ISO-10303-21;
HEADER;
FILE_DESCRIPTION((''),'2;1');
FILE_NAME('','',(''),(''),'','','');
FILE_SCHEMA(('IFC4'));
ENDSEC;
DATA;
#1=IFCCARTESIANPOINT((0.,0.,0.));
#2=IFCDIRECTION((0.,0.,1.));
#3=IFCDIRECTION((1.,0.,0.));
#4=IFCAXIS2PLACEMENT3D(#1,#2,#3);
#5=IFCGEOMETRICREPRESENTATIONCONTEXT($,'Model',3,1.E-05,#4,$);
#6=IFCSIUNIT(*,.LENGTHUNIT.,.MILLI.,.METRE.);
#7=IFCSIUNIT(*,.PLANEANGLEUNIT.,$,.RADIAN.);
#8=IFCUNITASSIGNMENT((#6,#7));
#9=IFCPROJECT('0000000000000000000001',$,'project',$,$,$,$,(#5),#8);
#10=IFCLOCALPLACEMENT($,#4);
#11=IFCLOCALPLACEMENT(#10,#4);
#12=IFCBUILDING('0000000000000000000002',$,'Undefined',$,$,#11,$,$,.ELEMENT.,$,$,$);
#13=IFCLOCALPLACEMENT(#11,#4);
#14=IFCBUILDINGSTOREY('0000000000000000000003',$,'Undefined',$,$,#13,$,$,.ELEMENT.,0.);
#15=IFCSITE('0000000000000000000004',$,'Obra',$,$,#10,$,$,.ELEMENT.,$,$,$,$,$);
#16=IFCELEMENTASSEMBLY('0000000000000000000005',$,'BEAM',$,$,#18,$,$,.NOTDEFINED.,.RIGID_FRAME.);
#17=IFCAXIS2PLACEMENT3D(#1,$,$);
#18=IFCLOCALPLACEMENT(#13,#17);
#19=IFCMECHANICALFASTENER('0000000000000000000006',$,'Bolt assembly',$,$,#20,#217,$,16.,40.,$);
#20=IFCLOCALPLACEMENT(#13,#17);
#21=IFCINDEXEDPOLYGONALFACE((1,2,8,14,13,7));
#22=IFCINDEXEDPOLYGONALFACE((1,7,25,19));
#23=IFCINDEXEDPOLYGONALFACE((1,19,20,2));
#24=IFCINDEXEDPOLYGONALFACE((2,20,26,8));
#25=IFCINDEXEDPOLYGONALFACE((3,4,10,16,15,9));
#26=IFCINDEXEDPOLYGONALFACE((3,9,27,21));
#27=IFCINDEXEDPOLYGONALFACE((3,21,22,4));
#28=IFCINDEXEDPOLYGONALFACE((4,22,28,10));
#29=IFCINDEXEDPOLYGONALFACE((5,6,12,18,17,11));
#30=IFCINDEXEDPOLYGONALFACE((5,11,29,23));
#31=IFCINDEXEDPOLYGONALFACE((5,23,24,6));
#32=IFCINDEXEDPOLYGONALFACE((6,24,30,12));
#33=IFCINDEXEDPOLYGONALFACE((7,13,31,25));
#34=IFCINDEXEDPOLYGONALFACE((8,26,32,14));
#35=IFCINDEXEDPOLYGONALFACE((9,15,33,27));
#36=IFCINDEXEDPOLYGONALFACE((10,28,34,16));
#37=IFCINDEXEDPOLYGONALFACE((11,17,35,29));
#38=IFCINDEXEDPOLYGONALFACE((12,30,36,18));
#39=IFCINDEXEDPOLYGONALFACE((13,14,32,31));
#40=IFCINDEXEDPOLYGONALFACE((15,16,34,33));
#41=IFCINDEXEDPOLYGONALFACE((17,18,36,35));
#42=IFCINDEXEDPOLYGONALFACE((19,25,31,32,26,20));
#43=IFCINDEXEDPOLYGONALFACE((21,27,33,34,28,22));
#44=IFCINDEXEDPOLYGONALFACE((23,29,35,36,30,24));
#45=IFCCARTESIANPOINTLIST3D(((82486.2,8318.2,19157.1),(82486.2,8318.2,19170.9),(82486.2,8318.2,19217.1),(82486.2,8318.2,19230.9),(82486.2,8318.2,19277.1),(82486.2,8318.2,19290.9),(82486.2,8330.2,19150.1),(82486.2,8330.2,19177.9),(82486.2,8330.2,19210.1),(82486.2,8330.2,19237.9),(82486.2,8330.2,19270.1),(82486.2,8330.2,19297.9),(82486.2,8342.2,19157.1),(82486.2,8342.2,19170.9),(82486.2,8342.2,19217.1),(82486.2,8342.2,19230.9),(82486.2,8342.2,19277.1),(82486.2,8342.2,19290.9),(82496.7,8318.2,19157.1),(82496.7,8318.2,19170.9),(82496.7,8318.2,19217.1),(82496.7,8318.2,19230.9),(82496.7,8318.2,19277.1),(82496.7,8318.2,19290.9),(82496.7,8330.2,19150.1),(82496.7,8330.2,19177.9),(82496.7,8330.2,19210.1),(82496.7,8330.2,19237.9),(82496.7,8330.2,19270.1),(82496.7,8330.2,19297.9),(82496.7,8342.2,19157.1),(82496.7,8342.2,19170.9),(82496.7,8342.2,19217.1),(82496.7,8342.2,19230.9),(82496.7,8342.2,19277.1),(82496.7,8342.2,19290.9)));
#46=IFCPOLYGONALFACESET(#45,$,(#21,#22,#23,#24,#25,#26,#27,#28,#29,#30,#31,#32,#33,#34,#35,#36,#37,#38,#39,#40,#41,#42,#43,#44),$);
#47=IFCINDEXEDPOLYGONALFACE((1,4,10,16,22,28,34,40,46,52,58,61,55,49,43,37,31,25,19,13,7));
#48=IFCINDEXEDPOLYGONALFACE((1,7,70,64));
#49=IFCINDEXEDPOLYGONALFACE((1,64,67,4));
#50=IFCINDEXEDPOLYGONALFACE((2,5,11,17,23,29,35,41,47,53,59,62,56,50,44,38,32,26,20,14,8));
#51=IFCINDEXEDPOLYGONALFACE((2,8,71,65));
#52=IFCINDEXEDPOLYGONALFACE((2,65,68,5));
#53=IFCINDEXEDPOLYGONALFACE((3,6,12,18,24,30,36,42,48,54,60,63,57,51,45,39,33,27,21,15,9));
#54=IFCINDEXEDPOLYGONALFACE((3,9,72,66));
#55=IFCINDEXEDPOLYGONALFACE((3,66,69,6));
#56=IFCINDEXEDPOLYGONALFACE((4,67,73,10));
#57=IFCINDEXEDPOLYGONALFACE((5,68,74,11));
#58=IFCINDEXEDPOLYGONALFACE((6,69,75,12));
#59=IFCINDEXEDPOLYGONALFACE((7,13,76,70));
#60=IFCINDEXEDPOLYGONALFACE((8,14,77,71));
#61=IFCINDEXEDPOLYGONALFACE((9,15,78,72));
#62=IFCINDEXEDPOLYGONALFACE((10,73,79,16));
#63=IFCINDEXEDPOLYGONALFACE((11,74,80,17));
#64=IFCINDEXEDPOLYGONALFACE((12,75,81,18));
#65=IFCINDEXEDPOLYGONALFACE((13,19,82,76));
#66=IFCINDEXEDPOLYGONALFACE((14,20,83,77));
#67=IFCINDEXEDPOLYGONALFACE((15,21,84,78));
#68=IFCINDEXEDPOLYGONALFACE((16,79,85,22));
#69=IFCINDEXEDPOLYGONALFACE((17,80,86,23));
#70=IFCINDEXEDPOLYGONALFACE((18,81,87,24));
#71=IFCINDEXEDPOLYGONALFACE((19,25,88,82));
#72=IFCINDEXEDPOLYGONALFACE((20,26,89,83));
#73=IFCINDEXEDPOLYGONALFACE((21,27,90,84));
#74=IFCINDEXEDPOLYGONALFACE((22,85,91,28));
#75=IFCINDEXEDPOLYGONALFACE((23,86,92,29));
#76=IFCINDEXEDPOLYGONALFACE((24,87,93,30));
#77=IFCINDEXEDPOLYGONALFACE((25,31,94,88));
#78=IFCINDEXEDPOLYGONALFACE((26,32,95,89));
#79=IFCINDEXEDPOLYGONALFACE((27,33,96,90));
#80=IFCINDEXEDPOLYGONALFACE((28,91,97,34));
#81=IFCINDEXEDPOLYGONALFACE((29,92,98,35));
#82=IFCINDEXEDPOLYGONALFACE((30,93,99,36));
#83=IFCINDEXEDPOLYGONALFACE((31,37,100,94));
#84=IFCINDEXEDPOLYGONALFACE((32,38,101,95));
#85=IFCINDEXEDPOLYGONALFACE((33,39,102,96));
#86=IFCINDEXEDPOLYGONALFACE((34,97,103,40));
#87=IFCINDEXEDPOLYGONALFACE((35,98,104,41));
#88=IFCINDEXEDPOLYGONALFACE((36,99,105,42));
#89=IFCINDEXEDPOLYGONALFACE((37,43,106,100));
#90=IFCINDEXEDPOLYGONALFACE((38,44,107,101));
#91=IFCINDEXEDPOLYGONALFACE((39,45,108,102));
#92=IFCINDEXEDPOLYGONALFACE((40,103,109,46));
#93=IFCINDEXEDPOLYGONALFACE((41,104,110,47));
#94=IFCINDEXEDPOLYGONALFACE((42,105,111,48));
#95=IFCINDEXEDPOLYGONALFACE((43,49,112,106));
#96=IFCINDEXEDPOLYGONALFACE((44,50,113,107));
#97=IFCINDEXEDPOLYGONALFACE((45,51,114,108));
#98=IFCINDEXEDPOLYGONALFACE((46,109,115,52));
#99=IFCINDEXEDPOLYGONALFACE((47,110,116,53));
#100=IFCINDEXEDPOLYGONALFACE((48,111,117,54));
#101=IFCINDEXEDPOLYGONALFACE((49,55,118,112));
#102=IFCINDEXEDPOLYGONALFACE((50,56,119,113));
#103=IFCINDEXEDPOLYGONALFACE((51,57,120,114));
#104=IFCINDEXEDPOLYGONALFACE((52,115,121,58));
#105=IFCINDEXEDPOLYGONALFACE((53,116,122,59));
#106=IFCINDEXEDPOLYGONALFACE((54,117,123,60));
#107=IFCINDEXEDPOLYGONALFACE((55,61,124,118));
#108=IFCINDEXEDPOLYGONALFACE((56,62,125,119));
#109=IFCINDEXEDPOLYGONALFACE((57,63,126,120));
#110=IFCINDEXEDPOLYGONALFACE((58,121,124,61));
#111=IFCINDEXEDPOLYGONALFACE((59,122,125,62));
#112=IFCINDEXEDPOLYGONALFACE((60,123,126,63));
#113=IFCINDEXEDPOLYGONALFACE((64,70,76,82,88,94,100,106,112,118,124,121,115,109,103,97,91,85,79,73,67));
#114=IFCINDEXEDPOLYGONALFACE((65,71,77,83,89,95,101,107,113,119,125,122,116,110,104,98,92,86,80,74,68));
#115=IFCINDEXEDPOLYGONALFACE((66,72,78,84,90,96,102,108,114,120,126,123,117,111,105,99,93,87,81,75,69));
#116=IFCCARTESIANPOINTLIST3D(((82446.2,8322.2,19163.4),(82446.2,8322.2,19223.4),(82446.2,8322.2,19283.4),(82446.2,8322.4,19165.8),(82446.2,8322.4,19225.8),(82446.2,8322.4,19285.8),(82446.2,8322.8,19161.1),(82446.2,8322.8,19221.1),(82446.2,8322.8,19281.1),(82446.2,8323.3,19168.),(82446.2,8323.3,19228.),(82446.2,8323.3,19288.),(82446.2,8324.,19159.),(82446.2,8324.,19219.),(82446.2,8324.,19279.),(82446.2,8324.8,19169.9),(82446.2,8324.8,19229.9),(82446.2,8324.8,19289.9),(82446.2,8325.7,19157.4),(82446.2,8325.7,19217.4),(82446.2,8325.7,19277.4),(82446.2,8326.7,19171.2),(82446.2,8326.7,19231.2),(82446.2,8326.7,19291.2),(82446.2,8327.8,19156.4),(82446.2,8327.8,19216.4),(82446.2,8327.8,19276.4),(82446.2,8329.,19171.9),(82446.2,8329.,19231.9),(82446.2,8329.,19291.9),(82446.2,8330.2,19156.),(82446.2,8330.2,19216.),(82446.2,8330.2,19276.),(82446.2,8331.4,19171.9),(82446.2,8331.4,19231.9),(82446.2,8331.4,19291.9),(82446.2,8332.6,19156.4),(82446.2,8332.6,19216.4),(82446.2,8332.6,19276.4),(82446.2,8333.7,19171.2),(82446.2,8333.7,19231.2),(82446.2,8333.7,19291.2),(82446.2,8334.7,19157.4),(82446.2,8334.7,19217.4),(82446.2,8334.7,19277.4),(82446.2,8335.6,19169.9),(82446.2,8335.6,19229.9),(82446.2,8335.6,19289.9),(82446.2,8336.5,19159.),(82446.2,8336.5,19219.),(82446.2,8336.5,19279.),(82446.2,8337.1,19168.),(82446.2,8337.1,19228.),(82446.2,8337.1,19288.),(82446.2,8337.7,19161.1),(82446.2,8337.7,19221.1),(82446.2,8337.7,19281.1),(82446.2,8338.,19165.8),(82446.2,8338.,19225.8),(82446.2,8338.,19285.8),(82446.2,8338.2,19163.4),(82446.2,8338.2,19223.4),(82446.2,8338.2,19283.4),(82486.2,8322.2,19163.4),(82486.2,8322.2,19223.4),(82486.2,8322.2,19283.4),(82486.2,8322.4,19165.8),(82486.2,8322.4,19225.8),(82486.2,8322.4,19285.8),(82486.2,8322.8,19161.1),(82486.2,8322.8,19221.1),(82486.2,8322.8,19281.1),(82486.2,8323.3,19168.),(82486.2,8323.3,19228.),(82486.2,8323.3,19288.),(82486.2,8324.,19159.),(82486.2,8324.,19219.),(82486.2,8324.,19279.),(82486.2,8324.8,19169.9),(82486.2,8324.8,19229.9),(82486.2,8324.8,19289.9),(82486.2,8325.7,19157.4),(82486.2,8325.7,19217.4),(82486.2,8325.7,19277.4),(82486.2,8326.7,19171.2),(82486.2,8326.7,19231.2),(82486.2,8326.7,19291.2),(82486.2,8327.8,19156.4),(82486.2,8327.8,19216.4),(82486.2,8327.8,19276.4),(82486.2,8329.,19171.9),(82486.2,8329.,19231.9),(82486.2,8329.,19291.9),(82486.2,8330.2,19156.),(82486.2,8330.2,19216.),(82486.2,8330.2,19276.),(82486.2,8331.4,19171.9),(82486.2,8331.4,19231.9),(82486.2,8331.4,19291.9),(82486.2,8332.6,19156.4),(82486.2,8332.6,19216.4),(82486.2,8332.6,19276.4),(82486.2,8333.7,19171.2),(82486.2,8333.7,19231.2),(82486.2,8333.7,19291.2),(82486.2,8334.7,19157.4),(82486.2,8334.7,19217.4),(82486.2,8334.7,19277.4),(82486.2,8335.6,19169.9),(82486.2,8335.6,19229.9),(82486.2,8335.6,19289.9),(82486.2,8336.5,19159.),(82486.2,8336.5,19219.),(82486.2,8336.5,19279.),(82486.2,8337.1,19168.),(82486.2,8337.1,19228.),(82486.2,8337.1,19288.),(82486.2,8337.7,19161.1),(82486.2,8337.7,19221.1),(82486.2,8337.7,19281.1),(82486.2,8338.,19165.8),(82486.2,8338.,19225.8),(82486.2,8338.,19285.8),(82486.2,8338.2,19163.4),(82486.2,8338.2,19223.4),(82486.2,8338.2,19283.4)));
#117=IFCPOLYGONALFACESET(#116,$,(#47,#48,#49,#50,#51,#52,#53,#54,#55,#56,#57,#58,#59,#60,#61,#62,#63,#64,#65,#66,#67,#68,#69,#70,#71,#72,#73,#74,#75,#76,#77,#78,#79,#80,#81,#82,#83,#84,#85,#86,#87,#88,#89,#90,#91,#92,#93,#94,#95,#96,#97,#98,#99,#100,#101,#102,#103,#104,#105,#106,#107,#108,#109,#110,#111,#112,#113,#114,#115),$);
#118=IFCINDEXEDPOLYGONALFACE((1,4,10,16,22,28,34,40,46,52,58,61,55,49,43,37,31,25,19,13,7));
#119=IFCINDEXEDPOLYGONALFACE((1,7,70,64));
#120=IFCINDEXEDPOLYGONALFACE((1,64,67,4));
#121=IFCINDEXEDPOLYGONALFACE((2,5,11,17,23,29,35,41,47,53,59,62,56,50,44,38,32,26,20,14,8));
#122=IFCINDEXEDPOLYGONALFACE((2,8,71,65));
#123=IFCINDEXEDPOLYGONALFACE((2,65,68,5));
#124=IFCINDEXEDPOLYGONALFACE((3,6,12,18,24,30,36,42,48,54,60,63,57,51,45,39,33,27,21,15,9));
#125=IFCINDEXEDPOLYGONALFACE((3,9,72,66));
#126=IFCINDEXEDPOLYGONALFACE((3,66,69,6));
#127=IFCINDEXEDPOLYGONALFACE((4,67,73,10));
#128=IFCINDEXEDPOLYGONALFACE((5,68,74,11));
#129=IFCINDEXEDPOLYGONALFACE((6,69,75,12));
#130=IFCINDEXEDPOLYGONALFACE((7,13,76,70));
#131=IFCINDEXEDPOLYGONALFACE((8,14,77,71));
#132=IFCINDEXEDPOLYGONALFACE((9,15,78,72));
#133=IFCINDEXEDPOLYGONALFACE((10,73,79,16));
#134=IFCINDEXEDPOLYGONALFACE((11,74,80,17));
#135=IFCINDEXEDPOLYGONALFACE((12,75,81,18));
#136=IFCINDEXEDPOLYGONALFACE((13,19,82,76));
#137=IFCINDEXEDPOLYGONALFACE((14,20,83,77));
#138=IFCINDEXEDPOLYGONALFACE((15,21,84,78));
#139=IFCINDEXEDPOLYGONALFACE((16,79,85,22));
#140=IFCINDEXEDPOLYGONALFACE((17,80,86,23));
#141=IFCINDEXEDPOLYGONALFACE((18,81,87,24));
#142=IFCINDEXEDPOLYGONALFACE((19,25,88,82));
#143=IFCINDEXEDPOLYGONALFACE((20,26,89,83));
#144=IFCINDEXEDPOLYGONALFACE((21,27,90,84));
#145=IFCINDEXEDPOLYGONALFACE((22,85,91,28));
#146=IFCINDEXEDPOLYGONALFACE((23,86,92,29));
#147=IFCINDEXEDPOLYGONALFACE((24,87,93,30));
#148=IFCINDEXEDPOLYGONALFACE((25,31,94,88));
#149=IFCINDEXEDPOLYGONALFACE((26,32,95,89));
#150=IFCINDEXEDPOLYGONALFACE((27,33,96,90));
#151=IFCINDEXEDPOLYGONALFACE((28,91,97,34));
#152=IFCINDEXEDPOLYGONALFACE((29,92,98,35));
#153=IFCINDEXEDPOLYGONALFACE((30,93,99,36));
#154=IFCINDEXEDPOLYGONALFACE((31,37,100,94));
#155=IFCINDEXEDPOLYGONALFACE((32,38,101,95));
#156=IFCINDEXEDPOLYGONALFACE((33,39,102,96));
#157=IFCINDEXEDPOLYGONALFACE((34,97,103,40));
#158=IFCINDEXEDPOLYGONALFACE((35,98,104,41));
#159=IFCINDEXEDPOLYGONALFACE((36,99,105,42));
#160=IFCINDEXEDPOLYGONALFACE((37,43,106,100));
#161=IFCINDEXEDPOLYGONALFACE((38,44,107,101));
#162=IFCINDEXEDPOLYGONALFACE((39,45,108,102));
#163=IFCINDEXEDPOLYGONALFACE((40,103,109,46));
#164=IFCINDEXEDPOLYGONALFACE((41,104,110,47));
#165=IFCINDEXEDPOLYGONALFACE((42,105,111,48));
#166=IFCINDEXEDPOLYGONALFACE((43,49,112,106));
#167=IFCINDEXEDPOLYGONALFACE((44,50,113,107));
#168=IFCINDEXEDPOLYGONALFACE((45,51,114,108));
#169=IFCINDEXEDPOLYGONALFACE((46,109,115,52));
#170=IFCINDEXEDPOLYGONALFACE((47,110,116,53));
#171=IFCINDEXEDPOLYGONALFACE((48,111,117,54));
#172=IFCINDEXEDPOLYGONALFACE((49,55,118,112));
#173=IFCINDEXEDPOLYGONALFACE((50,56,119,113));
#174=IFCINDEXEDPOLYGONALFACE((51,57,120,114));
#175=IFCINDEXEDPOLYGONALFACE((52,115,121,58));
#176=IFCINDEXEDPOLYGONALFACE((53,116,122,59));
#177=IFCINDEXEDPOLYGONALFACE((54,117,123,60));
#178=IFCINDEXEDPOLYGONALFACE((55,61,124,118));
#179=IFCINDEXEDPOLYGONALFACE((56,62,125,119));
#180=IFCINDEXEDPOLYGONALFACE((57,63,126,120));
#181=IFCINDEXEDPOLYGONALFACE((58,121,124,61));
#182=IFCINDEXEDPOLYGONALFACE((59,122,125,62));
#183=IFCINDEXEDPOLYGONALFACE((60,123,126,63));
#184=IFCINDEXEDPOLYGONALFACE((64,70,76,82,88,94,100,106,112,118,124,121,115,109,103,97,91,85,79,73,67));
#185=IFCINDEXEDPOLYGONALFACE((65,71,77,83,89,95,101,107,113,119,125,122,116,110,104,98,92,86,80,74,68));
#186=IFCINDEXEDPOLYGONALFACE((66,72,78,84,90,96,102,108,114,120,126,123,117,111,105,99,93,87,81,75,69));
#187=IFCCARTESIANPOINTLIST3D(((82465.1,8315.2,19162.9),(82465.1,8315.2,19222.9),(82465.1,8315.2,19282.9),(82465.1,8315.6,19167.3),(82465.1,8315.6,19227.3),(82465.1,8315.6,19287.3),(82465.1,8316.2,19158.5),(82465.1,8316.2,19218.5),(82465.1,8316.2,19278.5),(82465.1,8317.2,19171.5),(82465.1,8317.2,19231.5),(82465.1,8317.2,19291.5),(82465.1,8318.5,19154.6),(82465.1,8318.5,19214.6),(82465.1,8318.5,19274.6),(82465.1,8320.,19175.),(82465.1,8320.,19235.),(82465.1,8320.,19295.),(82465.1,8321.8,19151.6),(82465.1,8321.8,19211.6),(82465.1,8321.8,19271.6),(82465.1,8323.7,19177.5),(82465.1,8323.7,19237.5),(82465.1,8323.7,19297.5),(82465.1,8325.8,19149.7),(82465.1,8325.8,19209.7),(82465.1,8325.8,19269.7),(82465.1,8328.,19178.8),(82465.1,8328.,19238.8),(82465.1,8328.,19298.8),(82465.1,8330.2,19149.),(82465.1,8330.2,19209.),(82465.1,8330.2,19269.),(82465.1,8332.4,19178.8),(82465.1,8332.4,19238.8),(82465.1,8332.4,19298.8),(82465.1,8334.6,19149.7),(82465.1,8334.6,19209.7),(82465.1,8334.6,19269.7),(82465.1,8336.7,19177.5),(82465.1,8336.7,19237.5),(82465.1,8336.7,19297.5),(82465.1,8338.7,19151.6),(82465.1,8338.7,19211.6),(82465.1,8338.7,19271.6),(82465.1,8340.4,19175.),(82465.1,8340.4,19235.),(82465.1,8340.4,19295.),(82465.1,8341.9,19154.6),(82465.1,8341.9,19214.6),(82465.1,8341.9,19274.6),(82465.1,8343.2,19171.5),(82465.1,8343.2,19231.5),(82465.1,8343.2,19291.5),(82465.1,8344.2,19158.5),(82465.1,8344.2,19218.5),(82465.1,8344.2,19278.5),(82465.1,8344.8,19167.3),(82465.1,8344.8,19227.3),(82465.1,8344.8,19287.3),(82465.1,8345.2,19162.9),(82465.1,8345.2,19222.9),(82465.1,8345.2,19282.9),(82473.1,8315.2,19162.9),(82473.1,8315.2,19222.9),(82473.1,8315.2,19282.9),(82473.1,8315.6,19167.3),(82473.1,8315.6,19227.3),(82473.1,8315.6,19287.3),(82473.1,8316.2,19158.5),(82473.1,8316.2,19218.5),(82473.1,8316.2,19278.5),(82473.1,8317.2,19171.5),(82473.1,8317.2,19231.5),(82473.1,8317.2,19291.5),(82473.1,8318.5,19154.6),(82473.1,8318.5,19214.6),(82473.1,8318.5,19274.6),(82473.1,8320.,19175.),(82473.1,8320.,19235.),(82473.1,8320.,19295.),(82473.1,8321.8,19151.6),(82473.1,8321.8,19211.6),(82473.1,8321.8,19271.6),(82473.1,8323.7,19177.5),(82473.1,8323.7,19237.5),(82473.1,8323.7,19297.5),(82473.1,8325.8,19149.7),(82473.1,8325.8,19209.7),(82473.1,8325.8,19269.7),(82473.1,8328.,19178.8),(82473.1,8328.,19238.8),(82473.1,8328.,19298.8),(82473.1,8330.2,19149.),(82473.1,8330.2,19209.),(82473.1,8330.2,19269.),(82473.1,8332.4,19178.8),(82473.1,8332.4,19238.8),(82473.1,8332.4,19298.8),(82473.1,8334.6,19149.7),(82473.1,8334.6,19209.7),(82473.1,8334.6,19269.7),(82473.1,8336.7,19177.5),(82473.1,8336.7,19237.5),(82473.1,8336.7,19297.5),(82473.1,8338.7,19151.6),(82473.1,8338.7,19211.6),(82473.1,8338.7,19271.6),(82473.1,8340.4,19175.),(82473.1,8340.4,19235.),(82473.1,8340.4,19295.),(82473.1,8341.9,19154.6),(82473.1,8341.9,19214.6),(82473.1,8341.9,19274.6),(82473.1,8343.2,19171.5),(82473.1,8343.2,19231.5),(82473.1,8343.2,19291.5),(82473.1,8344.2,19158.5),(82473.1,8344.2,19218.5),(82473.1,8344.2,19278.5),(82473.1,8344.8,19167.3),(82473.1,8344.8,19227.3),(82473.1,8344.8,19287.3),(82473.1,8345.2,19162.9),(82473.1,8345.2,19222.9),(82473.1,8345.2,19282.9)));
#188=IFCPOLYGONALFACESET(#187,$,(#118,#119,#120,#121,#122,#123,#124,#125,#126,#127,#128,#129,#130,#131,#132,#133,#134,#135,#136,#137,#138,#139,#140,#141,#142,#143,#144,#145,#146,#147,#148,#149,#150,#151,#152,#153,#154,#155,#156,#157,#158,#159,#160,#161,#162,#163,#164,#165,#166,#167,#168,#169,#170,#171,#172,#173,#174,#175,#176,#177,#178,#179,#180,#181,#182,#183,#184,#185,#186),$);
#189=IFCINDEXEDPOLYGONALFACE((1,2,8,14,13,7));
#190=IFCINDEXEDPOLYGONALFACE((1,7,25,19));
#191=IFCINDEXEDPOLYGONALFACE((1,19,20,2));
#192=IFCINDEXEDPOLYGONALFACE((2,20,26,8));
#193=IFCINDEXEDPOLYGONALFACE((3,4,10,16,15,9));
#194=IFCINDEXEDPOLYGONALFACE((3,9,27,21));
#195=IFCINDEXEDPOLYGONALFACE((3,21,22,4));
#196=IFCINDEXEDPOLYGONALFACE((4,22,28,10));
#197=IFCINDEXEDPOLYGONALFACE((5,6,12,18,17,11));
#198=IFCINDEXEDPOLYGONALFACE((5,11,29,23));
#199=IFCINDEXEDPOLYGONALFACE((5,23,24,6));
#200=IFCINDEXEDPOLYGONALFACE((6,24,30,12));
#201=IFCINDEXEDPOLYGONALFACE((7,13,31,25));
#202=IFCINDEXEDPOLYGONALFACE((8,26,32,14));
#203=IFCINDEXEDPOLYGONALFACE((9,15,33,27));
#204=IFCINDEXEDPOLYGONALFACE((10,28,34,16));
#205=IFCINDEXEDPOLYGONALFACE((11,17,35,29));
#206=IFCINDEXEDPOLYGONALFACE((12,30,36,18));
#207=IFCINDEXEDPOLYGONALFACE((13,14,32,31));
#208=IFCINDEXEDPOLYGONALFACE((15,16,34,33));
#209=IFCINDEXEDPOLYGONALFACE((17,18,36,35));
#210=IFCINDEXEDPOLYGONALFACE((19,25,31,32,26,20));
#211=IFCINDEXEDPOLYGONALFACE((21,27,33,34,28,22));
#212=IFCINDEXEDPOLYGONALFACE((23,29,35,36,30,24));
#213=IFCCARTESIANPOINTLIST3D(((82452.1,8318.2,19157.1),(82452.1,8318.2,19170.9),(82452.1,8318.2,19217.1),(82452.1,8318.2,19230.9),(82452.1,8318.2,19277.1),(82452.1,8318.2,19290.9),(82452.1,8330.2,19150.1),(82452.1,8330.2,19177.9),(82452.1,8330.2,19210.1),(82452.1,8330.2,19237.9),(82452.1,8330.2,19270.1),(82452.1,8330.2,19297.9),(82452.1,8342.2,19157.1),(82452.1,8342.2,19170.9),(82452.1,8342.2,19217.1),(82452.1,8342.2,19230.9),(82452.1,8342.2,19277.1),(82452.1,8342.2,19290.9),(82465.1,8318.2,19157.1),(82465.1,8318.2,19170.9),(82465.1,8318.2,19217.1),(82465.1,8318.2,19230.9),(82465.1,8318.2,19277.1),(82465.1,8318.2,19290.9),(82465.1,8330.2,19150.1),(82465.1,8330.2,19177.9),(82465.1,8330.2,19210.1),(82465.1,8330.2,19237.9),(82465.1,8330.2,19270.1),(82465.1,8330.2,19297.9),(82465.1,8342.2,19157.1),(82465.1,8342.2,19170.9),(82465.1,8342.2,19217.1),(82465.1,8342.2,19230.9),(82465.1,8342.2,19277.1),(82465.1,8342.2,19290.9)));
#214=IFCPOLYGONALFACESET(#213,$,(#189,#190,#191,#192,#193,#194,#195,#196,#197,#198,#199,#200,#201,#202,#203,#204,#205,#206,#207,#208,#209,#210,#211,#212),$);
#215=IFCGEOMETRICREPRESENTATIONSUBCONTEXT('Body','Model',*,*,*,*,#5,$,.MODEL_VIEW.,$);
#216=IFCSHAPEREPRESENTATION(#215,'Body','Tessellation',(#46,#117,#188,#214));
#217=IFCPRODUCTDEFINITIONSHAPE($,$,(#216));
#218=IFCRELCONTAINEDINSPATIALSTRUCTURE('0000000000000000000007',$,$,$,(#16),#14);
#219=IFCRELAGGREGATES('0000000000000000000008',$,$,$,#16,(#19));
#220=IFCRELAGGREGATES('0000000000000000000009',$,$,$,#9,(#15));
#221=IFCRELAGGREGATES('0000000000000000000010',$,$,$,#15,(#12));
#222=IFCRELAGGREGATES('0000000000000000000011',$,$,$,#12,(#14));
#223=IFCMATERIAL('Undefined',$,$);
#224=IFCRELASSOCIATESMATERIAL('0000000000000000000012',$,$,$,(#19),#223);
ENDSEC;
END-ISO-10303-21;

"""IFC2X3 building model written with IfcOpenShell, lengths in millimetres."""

from ifc_helpers import new_model, si_unit, frame, origin_with_axes, origin_2d_with_axis, place, context, subcontext, project, spatial, polyline, circle, outline, extrude, source, transform, mapped, material, element, aggregate, save


model = new_model("IFC2X3")

# Units and contexts
model_context = context("Model", 3, precision=1e-05, world=origin_with_axes())
body_context = subcontext(model_context, "Body", "Model", "MODEL_VIEW")
ifc_project = project(units=[si_unit("LENGTHUNIT", "METRE", prefix="MILLI"), si_unit("PLANEANGLEUNIT", "RADIAN")], contexts=[model_context])

# Site, building, storey
site_placement = place(None, origin_with_axes())
site = spatial("IfcSite", under=ifc_project, at=site_placement, Name="Obra", CompositionType="ELEMENT")
building_placement = place(site_placement, origin_with_axes())
building = spatial("IfcBuilding", under=site, at=building_placement, Name="Undefined", CompositionType="ELEMENT")
storey_placement = place(building_placement, origin_with_axes())
storey = spatial("IfcBuildingStorey", under=building, at=storey_placement, Name="Undefined", CompositionType="ELEMENT", Elevation=0.0)

# Shared definitions
ifc_material_1 = material(Name="Undefined")

# Element assembly, mechanical fastener
shared_shape_1 = source(origin_with_axes(), body_context, "Body", "SweptSolid", [
    extrude(outline(polyline([(13.9, 0.0), (6.9, 12.0), (-6.9, 12.0), (-13.9, 0.0), (-6.9, -12.0), (6.9, -12.0), (13.9, 0.0)])), frame((0.0, -14.1, 0.0), z_axis=(0.0, 1.0, 0.0), x_axis=(1.0, 0.0, 0.0)), (0.0, 0.0, 1.0), 10.6),
    extrude(circle(Radius=8.0, at=origin_2d_with_axis()), frame((0.0, -3.5, 0.0), z_axis=(0.0, 1.0, 0.0), x_axis=(1.0, 0.0, 0.0)), (0.0, 0.0, 1.0), 40.0),
    extrude(circle(Radius=15.0, at=origin_2d_with_axis()), frame((0.0, 9.5, 0.0), z_axis=(0.0, 1.0, 0.0), x_axis=(1.0, 0.0, 0.0)), (0.0, 0.0, 1.0), 8.0),
    extrude(outline(polyline([(13.9, 0.0), (6.9, 12.0), (-6.9, 12.0), (-13.9, 0.0), (-6.9, -12.0), (6.9, -12.0), (13.9, 0.0)])), frame((0.0, 17.5, 0.0), z_axis=(0.0, 1.0, 0.0), x_axis=(1.0, 0.0, 0.0)), (0.0, 0.0, 1.0), 13.0),
])
assembly_1_placement = place(storey_placement, origin_with_axes())
assembly_1 = element("IfcElementAssembly", 1, at=assembly_1_placement, inside=storey, Name="BEAM", AssemblyPlace="NOTDEFINED", PredefinedType="RIGID_FRAME")
mechanical_fastener_1_placement = place(assembly_1_placement, frame((82482.6, 8280.2, 19319.0), z_axis=(0.0, 1.0, 0.0), x_axis=(0.0, 0.0, -1.0)))
mechanical_fastener_1 = element("IfcMechanicalFastener", 2, at=mechanical_fastener_1_placement, material=ifc_material_1, Name="Bolt assembly", NominalDiameter=16.0, NominalLength=40.0, context=body_context, shape_type="MappedRepresentation", body=[
    mapped(shared_shape_1, transform((35.0, 0.0, 50.0))),
    mapped(shared_shape_1, transform((95.0, 0.0, 50.0))),
    mapped(shared_shape_1, transform((155.0, 0.0, 50.0))),
])
aggregate(assembly_1, [mechanical_fastener_1])

save(model, "model.ifc")
